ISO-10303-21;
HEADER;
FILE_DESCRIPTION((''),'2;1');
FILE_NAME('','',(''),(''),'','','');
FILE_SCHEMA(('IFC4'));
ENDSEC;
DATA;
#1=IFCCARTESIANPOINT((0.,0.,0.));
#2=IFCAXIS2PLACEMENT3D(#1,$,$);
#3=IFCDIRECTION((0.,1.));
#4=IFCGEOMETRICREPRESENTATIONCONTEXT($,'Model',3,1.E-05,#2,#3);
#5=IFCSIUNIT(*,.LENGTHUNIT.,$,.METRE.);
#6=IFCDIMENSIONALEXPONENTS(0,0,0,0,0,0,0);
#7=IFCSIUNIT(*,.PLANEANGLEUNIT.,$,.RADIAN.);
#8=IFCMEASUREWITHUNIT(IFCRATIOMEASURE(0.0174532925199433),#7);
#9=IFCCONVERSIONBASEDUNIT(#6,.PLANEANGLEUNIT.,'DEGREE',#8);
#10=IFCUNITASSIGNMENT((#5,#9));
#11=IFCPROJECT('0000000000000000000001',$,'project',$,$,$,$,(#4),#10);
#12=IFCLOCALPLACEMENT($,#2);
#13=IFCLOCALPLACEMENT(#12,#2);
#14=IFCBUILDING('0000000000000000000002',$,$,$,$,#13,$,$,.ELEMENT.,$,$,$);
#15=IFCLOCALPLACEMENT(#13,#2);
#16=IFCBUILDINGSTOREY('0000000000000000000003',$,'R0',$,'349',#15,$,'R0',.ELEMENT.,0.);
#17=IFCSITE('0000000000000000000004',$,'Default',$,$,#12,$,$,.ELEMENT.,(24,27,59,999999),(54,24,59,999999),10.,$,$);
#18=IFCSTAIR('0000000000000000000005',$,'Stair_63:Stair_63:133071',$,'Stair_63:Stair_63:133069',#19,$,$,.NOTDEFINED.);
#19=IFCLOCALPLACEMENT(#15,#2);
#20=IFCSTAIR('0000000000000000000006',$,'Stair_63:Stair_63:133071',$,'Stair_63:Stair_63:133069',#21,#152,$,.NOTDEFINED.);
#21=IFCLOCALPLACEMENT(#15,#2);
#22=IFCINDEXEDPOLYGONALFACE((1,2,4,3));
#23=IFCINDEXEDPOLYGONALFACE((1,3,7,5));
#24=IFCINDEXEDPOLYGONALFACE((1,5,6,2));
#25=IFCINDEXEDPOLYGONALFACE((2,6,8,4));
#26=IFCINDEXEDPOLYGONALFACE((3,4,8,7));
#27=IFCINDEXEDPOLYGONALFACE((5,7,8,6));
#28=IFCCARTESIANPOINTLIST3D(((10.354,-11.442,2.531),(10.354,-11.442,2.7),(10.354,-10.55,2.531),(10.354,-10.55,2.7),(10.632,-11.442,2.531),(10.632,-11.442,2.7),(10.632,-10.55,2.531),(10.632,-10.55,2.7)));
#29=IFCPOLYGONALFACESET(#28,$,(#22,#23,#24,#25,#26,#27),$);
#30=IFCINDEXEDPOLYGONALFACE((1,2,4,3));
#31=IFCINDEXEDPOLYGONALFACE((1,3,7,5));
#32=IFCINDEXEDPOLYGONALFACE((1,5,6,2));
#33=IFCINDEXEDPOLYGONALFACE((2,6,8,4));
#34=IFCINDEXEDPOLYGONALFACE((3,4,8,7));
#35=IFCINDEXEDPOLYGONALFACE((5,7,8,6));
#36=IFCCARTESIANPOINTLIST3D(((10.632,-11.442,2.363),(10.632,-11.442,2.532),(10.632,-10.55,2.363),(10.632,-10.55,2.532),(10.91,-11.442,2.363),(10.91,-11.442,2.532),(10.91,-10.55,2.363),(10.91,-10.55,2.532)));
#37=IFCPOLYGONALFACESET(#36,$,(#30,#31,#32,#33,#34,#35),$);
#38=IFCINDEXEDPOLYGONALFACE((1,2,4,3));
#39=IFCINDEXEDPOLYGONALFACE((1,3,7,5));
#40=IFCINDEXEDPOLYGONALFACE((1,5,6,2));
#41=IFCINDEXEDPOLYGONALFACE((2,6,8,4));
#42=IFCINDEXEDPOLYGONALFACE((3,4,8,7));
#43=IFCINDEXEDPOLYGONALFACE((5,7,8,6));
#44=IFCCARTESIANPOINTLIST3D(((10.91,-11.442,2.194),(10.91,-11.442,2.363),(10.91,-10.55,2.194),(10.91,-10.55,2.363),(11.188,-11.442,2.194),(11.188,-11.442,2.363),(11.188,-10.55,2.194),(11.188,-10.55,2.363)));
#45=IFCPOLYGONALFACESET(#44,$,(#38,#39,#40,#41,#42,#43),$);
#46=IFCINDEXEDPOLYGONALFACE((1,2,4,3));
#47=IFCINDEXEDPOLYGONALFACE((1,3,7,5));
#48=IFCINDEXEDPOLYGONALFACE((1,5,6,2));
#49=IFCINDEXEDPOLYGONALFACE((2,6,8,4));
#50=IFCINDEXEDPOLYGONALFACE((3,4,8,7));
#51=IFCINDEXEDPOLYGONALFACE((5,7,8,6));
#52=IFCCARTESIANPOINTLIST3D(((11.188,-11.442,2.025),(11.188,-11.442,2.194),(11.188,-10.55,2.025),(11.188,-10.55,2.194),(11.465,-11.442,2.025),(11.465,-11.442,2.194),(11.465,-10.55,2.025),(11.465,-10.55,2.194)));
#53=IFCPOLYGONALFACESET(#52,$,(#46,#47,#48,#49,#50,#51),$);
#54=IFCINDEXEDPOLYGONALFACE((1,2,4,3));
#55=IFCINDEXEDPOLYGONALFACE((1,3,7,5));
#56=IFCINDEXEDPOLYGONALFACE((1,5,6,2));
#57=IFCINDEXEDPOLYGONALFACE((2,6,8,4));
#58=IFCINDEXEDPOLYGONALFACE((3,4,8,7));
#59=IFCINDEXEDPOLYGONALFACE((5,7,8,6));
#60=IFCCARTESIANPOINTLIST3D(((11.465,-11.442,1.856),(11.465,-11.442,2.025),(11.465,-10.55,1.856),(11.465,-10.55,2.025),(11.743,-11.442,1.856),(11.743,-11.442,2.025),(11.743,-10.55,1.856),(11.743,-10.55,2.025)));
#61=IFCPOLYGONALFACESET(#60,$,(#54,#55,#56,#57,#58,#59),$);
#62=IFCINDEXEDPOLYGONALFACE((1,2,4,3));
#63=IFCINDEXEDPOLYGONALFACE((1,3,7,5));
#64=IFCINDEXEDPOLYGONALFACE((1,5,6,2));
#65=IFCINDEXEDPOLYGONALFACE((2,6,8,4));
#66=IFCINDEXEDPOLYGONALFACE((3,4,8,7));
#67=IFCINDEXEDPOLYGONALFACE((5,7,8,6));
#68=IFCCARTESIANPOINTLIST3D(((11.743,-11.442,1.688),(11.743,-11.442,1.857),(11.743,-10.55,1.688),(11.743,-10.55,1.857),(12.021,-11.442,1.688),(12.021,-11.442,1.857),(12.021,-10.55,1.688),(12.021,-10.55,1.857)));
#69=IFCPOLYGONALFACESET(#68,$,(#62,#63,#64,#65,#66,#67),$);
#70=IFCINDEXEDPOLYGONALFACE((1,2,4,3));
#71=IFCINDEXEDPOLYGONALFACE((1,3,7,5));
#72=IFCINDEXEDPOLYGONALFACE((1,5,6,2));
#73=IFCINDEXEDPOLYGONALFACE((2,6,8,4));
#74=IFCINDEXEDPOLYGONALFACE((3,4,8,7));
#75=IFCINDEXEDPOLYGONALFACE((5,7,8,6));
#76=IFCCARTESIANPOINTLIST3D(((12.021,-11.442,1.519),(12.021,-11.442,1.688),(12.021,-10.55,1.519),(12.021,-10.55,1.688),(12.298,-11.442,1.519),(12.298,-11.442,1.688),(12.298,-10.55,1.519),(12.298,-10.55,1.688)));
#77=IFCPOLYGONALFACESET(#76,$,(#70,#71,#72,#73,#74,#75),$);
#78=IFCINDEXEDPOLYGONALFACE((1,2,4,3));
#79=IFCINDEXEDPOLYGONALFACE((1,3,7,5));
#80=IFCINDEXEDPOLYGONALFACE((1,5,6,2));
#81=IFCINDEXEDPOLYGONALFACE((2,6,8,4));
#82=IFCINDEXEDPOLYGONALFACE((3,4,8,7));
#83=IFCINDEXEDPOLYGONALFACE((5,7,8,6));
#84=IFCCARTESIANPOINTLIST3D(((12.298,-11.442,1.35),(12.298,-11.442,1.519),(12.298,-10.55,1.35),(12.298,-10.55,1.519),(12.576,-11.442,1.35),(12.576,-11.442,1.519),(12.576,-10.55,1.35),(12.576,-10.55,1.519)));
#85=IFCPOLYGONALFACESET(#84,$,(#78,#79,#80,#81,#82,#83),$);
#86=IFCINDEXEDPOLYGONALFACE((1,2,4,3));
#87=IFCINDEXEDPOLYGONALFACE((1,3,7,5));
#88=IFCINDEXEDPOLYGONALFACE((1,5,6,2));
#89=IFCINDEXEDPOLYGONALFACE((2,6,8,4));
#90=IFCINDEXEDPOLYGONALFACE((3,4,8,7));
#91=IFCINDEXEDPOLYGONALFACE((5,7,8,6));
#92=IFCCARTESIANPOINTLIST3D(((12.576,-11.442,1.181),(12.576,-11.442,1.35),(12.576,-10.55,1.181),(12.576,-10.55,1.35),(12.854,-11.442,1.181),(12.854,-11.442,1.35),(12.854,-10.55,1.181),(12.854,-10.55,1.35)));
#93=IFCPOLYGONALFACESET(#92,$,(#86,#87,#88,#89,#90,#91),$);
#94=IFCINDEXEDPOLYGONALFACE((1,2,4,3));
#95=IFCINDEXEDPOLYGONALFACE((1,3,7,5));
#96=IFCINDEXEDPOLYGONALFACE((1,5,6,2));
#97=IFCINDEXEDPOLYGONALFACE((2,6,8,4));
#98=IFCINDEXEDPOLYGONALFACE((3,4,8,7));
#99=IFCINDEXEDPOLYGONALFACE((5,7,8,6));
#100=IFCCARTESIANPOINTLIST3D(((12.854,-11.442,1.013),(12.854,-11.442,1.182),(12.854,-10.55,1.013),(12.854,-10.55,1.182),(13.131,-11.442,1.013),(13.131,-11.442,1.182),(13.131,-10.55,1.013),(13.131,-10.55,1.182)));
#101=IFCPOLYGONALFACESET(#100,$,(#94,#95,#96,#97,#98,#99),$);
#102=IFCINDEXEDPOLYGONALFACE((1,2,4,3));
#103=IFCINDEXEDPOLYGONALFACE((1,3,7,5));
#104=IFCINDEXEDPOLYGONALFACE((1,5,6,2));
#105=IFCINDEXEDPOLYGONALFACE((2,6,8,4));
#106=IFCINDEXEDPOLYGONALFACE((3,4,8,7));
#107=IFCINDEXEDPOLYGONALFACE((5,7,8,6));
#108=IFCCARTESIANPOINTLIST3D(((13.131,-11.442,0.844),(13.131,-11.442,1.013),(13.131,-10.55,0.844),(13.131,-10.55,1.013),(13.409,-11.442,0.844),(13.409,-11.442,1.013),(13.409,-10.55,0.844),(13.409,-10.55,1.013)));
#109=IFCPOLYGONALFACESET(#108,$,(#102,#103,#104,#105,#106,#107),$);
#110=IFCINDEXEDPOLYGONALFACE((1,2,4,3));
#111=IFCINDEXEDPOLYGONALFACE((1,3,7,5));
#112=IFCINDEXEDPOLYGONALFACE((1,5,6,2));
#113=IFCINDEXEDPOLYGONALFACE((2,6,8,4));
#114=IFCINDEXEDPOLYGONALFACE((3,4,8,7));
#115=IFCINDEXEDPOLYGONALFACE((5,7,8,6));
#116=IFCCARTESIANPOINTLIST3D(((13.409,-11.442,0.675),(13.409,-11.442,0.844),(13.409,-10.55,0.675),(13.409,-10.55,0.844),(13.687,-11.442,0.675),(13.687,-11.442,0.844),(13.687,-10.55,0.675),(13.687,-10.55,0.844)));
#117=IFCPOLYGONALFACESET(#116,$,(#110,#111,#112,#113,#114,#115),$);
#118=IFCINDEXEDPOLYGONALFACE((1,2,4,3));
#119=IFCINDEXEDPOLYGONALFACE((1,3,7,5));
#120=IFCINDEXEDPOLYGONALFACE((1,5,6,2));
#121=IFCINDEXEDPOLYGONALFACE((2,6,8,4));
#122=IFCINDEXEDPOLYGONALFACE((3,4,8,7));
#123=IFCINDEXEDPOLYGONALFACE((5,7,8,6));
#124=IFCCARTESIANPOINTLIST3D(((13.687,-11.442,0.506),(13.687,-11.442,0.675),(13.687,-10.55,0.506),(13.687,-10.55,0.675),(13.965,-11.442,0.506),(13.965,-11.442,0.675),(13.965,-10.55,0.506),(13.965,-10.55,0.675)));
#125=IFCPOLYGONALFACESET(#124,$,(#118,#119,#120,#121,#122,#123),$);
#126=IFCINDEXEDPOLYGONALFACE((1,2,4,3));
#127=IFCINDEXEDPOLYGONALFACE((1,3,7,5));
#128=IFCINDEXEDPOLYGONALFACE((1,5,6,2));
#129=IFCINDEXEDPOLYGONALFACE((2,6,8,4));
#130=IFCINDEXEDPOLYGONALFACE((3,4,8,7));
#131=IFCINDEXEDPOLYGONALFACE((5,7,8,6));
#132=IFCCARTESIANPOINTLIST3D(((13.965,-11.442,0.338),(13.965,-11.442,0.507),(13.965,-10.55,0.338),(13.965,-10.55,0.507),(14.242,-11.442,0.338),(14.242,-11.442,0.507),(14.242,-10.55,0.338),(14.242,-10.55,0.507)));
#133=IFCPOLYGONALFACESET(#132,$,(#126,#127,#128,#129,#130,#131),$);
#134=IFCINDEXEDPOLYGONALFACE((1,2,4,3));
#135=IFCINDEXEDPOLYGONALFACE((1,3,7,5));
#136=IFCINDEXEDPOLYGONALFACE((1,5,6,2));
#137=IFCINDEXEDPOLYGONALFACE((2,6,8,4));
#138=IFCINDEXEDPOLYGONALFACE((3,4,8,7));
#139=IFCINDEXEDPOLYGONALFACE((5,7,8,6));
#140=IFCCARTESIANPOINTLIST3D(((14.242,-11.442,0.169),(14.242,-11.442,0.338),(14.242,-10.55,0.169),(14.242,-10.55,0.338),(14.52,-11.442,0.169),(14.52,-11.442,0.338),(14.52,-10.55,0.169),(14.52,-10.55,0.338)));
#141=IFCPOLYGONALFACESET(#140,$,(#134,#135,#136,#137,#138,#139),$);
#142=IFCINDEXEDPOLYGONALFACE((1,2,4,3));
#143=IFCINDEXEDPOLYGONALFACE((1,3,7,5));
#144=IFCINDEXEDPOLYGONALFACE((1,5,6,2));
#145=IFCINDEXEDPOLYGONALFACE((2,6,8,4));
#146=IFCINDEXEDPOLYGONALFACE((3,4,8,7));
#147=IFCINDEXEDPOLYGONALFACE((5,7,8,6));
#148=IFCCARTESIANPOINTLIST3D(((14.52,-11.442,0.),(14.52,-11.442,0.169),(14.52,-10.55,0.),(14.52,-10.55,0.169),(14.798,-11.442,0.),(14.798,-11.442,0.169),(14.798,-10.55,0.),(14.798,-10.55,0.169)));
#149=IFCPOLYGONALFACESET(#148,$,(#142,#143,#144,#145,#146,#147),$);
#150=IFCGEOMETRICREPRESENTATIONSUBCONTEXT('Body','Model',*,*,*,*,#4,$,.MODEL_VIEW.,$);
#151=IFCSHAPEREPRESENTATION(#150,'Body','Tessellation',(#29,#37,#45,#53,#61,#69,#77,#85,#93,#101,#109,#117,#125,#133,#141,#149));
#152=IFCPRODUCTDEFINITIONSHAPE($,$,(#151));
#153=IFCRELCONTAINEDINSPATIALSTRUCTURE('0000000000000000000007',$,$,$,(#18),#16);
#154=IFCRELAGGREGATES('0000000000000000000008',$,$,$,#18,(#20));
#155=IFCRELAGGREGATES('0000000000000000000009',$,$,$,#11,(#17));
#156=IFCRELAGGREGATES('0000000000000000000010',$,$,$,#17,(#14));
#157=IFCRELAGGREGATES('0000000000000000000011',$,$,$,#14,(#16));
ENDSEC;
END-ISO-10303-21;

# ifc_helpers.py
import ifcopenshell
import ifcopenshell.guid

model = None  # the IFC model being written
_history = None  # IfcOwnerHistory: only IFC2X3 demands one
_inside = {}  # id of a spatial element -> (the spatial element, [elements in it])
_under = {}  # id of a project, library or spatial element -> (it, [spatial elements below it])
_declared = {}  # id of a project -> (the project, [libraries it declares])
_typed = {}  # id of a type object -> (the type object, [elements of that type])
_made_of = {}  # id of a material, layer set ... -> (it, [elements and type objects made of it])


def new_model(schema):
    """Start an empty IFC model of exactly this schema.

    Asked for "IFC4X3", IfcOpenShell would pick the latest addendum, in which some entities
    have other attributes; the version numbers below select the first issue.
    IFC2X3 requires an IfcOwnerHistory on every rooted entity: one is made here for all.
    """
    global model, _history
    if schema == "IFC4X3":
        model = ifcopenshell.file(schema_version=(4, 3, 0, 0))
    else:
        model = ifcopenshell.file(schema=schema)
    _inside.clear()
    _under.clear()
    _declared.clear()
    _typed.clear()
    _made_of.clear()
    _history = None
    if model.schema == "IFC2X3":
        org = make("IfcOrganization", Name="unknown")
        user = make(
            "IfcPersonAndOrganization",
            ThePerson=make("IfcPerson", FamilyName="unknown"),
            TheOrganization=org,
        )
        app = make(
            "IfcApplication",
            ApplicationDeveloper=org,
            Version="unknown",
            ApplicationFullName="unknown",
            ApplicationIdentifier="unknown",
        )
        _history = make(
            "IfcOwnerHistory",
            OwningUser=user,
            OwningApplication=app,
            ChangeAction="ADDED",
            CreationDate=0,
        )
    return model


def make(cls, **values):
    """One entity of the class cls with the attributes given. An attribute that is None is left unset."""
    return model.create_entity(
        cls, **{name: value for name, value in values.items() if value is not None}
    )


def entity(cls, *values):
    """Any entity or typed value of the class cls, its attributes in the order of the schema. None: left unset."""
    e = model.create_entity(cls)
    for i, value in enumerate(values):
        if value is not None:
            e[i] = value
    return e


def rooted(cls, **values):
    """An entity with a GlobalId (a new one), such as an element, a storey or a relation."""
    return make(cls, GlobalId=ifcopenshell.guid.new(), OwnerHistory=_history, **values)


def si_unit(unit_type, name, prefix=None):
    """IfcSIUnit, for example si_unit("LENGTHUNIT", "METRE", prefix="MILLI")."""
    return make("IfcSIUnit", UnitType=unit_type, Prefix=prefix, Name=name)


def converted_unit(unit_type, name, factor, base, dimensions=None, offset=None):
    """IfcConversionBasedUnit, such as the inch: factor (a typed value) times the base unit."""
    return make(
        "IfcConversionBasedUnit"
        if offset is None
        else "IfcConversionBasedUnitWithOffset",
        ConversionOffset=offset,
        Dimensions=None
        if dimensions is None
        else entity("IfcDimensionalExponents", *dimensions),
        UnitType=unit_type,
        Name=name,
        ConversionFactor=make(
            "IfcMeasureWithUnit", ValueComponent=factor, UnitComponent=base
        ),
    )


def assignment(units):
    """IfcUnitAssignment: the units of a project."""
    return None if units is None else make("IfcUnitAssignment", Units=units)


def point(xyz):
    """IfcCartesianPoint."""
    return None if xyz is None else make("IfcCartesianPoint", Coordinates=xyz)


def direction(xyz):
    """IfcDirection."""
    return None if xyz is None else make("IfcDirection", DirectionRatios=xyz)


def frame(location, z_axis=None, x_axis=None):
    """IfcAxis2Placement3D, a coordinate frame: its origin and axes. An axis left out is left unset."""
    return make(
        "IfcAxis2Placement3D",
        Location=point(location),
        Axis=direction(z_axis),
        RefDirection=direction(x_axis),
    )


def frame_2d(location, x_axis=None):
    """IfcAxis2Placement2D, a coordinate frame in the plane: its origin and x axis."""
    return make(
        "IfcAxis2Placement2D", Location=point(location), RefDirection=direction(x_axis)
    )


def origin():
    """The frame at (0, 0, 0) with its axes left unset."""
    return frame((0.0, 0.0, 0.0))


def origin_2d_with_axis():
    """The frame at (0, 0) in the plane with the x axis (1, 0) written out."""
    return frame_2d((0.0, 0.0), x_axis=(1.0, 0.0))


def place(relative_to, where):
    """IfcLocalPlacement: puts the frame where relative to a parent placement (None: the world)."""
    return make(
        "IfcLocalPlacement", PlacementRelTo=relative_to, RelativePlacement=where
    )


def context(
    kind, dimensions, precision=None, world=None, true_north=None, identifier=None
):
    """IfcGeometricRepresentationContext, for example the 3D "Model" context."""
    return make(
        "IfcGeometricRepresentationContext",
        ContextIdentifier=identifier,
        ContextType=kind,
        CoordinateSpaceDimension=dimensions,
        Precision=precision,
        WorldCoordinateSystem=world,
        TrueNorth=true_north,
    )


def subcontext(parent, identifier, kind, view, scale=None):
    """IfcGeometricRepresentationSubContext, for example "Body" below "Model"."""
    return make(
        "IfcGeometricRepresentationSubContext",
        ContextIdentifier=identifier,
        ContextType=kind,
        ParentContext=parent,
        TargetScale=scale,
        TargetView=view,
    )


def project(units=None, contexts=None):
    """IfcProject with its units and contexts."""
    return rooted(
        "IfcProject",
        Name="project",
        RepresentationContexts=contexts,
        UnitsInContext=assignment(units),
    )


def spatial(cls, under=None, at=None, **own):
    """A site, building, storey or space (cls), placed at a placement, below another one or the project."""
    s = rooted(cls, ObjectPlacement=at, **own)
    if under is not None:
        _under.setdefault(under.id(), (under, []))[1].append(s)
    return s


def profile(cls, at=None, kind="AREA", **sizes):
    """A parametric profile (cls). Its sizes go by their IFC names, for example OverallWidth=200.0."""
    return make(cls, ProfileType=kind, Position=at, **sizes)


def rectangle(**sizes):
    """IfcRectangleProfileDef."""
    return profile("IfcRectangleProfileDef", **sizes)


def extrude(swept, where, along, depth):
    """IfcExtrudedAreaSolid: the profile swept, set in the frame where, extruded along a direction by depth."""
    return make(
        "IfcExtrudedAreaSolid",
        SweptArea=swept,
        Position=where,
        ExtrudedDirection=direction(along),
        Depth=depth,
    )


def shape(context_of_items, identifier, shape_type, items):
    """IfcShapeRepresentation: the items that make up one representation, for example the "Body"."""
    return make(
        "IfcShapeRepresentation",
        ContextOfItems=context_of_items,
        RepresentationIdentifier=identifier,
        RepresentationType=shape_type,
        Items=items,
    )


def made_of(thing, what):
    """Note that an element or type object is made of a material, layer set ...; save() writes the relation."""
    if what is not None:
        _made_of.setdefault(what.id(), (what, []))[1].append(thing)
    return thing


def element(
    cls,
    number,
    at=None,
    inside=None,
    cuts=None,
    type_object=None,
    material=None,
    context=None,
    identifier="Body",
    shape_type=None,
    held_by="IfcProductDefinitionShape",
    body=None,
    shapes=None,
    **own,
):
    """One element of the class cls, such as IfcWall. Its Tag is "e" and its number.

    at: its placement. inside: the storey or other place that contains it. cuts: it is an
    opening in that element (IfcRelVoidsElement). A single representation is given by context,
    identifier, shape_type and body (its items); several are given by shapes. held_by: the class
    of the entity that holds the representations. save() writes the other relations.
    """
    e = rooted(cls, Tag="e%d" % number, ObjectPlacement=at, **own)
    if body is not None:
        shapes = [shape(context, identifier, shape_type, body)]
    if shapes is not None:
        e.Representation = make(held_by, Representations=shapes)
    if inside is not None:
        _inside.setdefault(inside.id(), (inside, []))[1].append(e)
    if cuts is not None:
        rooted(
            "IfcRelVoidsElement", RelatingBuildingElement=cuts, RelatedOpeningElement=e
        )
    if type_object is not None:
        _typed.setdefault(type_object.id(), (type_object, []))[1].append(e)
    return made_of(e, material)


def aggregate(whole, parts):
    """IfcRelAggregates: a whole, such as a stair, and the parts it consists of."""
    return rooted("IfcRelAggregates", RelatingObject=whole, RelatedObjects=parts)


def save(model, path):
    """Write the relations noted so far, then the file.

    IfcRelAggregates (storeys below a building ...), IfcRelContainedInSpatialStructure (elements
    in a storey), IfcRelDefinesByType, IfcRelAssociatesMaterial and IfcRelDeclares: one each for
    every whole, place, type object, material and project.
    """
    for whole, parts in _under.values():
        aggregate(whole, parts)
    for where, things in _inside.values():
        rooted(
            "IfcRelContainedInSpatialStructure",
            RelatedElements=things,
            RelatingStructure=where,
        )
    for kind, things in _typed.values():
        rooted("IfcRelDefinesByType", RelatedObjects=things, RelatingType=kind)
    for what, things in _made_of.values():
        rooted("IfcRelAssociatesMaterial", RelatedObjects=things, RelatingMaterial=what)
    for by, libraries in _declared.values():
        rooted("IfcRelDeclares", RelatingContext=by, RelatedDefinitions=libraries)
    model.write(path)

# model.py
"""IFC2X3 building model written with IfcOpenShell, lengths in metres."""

from ifc_helpers import new_model, entity, si_unit, converted_unit, direction, frame, frame_2d, origin, origin_2d_with_axis, place, context, subcontext, project, spatial, rectangle, extrude, element, aggregate, save


model = new_model("IFC2X3")

# Units and contexts
model_context = context("Model", 3, precision=1e-05, world=origin(), true_north=direction((0.0, 1.0)))
body_context = subcontext(model_context, "Body", "Model", "MODEL_VIEW")
ifc_project = project(units=[si_unit("LENGTHUNIT", "METRE"), converted_unit("PLANEANGLEUNIT", "DEGREE", entity("IfcRatioMeasure", 0.0174532925199433), si_unit("PLANEANGLEUNIT", "RADIAN"), dimensions=[0, 0, 0, 0, 0, 0, 0])], contexts=[model_context])

# Site, building, storey
site_placement = place(None, origin())
site = spatial("IfcSite", under=ifc_project, at=site_placement, Name="Default", CompositionType="ELEMENT", RefLatitude=(24, 27, 59, 999999), RefLongitude=(54, 24, 59, 999999), RefElevation=10.0)
building_placement = place(site_placement, origin())
building = spatial("IfcBuilding", under=site, at=building_placement, CompositionType="ELEMENT")
storey_placement = place(building_placement, origin())
storey = spatial("IfcBuildingStorey", under=building, at=storey_placement, Name="R0", ObjectType="349", LongName="R0", CompositionType="ELEMENT", Elevation=0.0)

# Stairs
stair_1_placement = place(storey_placement, origin())
stair_1 = element("IfcStair", 1, at=stair_1_placement, inside=storey, Name="Stair_63:Stair_63:133071", ObjectType="Stair_63:Stair_63:133069", ShapeType="NOTDEFINED")
stair_2_placement = place(stair_1_placement, origin())
stair_2 = element("IfcStair", 2, at=stair_2_placement, Name="Stair_63:Stair_63:133071", ObjectType="Stair_63:Stair_63:133069", ShapeType="NOTDEFINED", context=body_context, shape_type="SweptSolid", body=[
    extrude(rectangle(XDim=0.892, YDim=0.278, at=origin_2d_with_axis()), frame((10.493, -10.996, 2.531), z_axis=(0.0, 0.0, 1.0), x_axis=(0.0, -1.0, 0.0)), (0.0, 0.0, 1.0), 0.169),
    extrude(rectangle(XDim=0.892, YDim=0.278, at=frame_2d((0.0, 0.0), x_axis=(1.0, 0.0))), frame((10.771, -10.996, 2.363), z_axis=(0.0, 0.0, 1.0), x_axis=(0.0, -1.0, 0.0)), (0.0, 0.0, 1.0), 0.169),
    extrude(rectangle(XDim=0.892, YDim=0.278, at=frame_2d((0.0, 0.0), x_axis=(1.0, 0.0))), frame((11.049, -10.996, 2.194), z_axis=(0.0, 0.0, 1.0), x_axis=(0.0, -1.0, 0.0)), (0.0, 0.0, 1.0), 0.169),
    extrude(rectangle(XDim=0.892, YDim=0.277, at=frame_2d((0.0, 0.0), x_axis=(1.0, 0.0))), frame((11.3265, -10.996, 2.025), z_axis=(0.0, 0.0, 1.0), x_axis=(0.0, -1.0, 0.0)), (0.0, 0.0, 1.0), 0.169),
    extrude(rectangle(XDim=0.892, YDim=0.278, at=frame_2d((0.0, 0.0), x_axis=(1.0, 0.0))), frame((11.604, -10.996, 1.856), z_axis=(0.0, 0.0, 1.0), x_axis=(0.0, -1.0, 0.0)), (0.0, 0.0, 1.0), 0.169),
    extrude(rectangle(XDim=0.892, YDim=0.278, at=origin_2d_with_axis()), frame((11.882, -10.996, 1.688), z_axis=(0.0, 0.0, 1.0), x_axis=(0.0, -1.0, 0.0)), (0.0, 0.0, 1.0), 0.169),
    extrude(rectangle(XDim=0.892, YDim=0.277, at=frame_2d((0.0, 0.0), x_axis=(1.0, 0.0))), frame((12.1595, -10.996, 1.519), z_axis=(0.0, 0.0, 1.0), x_axis=(0.0, -1.0, 0.0)), (0.0, 0.0, 1.0), 0.169),
    extrude(rectangle(XDim=0.892, YDim=0.278, at=frame_2d((0.0, 0.0), x_axis=(1.0, 0.0))), frame((12.437, -10.996, 1.35), z_axis=(0.0, 0.0, 1.0), x_axis=(0.0, -1.0, 0.0)), (0.0, 0.0, 1.0), 0.169),
    extrude(rectangle(XDim=0.892, YDim=0.278, at=origin_2d_with_axis()), frame((12.715, -10.996, 1.181), z_axis=(0.0, 0.0, 1.0), x_axis=(0.0, -1.0, 0.0)), (0.0, 0.0, 1.0), 0.169),
    extrude(rectangle(XDim=0.892, YDim=0.277, at=origin_2d_with_axis()), frame((12.9925, -10.996, 1.013), z_axis=(0.0, 0.0, 1.0), x_axis=(0.0, -1.0, 0.0)), (0.0, 0.0, 1.0), 0.169),
    extrude(rectangle(XDim=0.892, YDim=0.278, at=frame_2d((0.0, 0.0), x_axis=(1.0, 0.0))), frame((13.27, -10.996, 0.844), z_axis=(0.0, 0.0, 1.0), x_axis=(0.0, -1.0, 0.0)), (0.0, 0.0, 1.0), 0.169),
    extrude(rectangle(XDim=0.892, YDim=0.278, at=frame_2d((0.0, 0.0), x_axis=(1.0, 0.0))), frame((13.548, -10.996, 0.675), z_axis=(0.0, 0.0, 1.0), x_axis=(0.0, -1.0, 0.0)), (0.0, 0.0, 1.0), 0.169),
    extrude(rectangle(XDim=0.892, YDim=0.278, at=frame_2d((0.0, 0.0), x_axis=(1.0, 0.0))), frame((13.826, -10.996, 0.506), z_axis=(0.0, 0.0, 1.0), x_axis=(0.0, -1.0, 0.0)), (0.0, 0.0, 1.0), 0.169),
    extrude(rectangle(XDim=0.892, YDim=0.277, at=origin_2d_with_axis()), frame((14.1035, -10.996, 0.338), z_axis=(0.0, 0.0, 1.0), x_axis=(0.0, -1.0, 0.0)), (0.0, 0.0, 1.0), 0.169),
    extrude(rectangle(XDim=0.892, YDim=0.278, at=origin_2d_with_axis()), frame((14.381, -10.996, 0.169), z_axis=(0.0, 0.0, 1.0), x_axis=(0.0, -1.0, 0.0)), (0.0, 0.0, 1.0), 0.169),
    extrude(rectangle(XDim=0.892, YDim=0.278, at=origin_2d_with_axis()), frame((14.659, -10.996, 0.0), z_axis=(0.0, 0.0, 1.0), x_axis=(0.0, -1.0, 0.0)), (0.0, 0.0, 1.0), 0.169),
])
aggregate(stair_1, [stair_2])

save(model, "model.ifc")
